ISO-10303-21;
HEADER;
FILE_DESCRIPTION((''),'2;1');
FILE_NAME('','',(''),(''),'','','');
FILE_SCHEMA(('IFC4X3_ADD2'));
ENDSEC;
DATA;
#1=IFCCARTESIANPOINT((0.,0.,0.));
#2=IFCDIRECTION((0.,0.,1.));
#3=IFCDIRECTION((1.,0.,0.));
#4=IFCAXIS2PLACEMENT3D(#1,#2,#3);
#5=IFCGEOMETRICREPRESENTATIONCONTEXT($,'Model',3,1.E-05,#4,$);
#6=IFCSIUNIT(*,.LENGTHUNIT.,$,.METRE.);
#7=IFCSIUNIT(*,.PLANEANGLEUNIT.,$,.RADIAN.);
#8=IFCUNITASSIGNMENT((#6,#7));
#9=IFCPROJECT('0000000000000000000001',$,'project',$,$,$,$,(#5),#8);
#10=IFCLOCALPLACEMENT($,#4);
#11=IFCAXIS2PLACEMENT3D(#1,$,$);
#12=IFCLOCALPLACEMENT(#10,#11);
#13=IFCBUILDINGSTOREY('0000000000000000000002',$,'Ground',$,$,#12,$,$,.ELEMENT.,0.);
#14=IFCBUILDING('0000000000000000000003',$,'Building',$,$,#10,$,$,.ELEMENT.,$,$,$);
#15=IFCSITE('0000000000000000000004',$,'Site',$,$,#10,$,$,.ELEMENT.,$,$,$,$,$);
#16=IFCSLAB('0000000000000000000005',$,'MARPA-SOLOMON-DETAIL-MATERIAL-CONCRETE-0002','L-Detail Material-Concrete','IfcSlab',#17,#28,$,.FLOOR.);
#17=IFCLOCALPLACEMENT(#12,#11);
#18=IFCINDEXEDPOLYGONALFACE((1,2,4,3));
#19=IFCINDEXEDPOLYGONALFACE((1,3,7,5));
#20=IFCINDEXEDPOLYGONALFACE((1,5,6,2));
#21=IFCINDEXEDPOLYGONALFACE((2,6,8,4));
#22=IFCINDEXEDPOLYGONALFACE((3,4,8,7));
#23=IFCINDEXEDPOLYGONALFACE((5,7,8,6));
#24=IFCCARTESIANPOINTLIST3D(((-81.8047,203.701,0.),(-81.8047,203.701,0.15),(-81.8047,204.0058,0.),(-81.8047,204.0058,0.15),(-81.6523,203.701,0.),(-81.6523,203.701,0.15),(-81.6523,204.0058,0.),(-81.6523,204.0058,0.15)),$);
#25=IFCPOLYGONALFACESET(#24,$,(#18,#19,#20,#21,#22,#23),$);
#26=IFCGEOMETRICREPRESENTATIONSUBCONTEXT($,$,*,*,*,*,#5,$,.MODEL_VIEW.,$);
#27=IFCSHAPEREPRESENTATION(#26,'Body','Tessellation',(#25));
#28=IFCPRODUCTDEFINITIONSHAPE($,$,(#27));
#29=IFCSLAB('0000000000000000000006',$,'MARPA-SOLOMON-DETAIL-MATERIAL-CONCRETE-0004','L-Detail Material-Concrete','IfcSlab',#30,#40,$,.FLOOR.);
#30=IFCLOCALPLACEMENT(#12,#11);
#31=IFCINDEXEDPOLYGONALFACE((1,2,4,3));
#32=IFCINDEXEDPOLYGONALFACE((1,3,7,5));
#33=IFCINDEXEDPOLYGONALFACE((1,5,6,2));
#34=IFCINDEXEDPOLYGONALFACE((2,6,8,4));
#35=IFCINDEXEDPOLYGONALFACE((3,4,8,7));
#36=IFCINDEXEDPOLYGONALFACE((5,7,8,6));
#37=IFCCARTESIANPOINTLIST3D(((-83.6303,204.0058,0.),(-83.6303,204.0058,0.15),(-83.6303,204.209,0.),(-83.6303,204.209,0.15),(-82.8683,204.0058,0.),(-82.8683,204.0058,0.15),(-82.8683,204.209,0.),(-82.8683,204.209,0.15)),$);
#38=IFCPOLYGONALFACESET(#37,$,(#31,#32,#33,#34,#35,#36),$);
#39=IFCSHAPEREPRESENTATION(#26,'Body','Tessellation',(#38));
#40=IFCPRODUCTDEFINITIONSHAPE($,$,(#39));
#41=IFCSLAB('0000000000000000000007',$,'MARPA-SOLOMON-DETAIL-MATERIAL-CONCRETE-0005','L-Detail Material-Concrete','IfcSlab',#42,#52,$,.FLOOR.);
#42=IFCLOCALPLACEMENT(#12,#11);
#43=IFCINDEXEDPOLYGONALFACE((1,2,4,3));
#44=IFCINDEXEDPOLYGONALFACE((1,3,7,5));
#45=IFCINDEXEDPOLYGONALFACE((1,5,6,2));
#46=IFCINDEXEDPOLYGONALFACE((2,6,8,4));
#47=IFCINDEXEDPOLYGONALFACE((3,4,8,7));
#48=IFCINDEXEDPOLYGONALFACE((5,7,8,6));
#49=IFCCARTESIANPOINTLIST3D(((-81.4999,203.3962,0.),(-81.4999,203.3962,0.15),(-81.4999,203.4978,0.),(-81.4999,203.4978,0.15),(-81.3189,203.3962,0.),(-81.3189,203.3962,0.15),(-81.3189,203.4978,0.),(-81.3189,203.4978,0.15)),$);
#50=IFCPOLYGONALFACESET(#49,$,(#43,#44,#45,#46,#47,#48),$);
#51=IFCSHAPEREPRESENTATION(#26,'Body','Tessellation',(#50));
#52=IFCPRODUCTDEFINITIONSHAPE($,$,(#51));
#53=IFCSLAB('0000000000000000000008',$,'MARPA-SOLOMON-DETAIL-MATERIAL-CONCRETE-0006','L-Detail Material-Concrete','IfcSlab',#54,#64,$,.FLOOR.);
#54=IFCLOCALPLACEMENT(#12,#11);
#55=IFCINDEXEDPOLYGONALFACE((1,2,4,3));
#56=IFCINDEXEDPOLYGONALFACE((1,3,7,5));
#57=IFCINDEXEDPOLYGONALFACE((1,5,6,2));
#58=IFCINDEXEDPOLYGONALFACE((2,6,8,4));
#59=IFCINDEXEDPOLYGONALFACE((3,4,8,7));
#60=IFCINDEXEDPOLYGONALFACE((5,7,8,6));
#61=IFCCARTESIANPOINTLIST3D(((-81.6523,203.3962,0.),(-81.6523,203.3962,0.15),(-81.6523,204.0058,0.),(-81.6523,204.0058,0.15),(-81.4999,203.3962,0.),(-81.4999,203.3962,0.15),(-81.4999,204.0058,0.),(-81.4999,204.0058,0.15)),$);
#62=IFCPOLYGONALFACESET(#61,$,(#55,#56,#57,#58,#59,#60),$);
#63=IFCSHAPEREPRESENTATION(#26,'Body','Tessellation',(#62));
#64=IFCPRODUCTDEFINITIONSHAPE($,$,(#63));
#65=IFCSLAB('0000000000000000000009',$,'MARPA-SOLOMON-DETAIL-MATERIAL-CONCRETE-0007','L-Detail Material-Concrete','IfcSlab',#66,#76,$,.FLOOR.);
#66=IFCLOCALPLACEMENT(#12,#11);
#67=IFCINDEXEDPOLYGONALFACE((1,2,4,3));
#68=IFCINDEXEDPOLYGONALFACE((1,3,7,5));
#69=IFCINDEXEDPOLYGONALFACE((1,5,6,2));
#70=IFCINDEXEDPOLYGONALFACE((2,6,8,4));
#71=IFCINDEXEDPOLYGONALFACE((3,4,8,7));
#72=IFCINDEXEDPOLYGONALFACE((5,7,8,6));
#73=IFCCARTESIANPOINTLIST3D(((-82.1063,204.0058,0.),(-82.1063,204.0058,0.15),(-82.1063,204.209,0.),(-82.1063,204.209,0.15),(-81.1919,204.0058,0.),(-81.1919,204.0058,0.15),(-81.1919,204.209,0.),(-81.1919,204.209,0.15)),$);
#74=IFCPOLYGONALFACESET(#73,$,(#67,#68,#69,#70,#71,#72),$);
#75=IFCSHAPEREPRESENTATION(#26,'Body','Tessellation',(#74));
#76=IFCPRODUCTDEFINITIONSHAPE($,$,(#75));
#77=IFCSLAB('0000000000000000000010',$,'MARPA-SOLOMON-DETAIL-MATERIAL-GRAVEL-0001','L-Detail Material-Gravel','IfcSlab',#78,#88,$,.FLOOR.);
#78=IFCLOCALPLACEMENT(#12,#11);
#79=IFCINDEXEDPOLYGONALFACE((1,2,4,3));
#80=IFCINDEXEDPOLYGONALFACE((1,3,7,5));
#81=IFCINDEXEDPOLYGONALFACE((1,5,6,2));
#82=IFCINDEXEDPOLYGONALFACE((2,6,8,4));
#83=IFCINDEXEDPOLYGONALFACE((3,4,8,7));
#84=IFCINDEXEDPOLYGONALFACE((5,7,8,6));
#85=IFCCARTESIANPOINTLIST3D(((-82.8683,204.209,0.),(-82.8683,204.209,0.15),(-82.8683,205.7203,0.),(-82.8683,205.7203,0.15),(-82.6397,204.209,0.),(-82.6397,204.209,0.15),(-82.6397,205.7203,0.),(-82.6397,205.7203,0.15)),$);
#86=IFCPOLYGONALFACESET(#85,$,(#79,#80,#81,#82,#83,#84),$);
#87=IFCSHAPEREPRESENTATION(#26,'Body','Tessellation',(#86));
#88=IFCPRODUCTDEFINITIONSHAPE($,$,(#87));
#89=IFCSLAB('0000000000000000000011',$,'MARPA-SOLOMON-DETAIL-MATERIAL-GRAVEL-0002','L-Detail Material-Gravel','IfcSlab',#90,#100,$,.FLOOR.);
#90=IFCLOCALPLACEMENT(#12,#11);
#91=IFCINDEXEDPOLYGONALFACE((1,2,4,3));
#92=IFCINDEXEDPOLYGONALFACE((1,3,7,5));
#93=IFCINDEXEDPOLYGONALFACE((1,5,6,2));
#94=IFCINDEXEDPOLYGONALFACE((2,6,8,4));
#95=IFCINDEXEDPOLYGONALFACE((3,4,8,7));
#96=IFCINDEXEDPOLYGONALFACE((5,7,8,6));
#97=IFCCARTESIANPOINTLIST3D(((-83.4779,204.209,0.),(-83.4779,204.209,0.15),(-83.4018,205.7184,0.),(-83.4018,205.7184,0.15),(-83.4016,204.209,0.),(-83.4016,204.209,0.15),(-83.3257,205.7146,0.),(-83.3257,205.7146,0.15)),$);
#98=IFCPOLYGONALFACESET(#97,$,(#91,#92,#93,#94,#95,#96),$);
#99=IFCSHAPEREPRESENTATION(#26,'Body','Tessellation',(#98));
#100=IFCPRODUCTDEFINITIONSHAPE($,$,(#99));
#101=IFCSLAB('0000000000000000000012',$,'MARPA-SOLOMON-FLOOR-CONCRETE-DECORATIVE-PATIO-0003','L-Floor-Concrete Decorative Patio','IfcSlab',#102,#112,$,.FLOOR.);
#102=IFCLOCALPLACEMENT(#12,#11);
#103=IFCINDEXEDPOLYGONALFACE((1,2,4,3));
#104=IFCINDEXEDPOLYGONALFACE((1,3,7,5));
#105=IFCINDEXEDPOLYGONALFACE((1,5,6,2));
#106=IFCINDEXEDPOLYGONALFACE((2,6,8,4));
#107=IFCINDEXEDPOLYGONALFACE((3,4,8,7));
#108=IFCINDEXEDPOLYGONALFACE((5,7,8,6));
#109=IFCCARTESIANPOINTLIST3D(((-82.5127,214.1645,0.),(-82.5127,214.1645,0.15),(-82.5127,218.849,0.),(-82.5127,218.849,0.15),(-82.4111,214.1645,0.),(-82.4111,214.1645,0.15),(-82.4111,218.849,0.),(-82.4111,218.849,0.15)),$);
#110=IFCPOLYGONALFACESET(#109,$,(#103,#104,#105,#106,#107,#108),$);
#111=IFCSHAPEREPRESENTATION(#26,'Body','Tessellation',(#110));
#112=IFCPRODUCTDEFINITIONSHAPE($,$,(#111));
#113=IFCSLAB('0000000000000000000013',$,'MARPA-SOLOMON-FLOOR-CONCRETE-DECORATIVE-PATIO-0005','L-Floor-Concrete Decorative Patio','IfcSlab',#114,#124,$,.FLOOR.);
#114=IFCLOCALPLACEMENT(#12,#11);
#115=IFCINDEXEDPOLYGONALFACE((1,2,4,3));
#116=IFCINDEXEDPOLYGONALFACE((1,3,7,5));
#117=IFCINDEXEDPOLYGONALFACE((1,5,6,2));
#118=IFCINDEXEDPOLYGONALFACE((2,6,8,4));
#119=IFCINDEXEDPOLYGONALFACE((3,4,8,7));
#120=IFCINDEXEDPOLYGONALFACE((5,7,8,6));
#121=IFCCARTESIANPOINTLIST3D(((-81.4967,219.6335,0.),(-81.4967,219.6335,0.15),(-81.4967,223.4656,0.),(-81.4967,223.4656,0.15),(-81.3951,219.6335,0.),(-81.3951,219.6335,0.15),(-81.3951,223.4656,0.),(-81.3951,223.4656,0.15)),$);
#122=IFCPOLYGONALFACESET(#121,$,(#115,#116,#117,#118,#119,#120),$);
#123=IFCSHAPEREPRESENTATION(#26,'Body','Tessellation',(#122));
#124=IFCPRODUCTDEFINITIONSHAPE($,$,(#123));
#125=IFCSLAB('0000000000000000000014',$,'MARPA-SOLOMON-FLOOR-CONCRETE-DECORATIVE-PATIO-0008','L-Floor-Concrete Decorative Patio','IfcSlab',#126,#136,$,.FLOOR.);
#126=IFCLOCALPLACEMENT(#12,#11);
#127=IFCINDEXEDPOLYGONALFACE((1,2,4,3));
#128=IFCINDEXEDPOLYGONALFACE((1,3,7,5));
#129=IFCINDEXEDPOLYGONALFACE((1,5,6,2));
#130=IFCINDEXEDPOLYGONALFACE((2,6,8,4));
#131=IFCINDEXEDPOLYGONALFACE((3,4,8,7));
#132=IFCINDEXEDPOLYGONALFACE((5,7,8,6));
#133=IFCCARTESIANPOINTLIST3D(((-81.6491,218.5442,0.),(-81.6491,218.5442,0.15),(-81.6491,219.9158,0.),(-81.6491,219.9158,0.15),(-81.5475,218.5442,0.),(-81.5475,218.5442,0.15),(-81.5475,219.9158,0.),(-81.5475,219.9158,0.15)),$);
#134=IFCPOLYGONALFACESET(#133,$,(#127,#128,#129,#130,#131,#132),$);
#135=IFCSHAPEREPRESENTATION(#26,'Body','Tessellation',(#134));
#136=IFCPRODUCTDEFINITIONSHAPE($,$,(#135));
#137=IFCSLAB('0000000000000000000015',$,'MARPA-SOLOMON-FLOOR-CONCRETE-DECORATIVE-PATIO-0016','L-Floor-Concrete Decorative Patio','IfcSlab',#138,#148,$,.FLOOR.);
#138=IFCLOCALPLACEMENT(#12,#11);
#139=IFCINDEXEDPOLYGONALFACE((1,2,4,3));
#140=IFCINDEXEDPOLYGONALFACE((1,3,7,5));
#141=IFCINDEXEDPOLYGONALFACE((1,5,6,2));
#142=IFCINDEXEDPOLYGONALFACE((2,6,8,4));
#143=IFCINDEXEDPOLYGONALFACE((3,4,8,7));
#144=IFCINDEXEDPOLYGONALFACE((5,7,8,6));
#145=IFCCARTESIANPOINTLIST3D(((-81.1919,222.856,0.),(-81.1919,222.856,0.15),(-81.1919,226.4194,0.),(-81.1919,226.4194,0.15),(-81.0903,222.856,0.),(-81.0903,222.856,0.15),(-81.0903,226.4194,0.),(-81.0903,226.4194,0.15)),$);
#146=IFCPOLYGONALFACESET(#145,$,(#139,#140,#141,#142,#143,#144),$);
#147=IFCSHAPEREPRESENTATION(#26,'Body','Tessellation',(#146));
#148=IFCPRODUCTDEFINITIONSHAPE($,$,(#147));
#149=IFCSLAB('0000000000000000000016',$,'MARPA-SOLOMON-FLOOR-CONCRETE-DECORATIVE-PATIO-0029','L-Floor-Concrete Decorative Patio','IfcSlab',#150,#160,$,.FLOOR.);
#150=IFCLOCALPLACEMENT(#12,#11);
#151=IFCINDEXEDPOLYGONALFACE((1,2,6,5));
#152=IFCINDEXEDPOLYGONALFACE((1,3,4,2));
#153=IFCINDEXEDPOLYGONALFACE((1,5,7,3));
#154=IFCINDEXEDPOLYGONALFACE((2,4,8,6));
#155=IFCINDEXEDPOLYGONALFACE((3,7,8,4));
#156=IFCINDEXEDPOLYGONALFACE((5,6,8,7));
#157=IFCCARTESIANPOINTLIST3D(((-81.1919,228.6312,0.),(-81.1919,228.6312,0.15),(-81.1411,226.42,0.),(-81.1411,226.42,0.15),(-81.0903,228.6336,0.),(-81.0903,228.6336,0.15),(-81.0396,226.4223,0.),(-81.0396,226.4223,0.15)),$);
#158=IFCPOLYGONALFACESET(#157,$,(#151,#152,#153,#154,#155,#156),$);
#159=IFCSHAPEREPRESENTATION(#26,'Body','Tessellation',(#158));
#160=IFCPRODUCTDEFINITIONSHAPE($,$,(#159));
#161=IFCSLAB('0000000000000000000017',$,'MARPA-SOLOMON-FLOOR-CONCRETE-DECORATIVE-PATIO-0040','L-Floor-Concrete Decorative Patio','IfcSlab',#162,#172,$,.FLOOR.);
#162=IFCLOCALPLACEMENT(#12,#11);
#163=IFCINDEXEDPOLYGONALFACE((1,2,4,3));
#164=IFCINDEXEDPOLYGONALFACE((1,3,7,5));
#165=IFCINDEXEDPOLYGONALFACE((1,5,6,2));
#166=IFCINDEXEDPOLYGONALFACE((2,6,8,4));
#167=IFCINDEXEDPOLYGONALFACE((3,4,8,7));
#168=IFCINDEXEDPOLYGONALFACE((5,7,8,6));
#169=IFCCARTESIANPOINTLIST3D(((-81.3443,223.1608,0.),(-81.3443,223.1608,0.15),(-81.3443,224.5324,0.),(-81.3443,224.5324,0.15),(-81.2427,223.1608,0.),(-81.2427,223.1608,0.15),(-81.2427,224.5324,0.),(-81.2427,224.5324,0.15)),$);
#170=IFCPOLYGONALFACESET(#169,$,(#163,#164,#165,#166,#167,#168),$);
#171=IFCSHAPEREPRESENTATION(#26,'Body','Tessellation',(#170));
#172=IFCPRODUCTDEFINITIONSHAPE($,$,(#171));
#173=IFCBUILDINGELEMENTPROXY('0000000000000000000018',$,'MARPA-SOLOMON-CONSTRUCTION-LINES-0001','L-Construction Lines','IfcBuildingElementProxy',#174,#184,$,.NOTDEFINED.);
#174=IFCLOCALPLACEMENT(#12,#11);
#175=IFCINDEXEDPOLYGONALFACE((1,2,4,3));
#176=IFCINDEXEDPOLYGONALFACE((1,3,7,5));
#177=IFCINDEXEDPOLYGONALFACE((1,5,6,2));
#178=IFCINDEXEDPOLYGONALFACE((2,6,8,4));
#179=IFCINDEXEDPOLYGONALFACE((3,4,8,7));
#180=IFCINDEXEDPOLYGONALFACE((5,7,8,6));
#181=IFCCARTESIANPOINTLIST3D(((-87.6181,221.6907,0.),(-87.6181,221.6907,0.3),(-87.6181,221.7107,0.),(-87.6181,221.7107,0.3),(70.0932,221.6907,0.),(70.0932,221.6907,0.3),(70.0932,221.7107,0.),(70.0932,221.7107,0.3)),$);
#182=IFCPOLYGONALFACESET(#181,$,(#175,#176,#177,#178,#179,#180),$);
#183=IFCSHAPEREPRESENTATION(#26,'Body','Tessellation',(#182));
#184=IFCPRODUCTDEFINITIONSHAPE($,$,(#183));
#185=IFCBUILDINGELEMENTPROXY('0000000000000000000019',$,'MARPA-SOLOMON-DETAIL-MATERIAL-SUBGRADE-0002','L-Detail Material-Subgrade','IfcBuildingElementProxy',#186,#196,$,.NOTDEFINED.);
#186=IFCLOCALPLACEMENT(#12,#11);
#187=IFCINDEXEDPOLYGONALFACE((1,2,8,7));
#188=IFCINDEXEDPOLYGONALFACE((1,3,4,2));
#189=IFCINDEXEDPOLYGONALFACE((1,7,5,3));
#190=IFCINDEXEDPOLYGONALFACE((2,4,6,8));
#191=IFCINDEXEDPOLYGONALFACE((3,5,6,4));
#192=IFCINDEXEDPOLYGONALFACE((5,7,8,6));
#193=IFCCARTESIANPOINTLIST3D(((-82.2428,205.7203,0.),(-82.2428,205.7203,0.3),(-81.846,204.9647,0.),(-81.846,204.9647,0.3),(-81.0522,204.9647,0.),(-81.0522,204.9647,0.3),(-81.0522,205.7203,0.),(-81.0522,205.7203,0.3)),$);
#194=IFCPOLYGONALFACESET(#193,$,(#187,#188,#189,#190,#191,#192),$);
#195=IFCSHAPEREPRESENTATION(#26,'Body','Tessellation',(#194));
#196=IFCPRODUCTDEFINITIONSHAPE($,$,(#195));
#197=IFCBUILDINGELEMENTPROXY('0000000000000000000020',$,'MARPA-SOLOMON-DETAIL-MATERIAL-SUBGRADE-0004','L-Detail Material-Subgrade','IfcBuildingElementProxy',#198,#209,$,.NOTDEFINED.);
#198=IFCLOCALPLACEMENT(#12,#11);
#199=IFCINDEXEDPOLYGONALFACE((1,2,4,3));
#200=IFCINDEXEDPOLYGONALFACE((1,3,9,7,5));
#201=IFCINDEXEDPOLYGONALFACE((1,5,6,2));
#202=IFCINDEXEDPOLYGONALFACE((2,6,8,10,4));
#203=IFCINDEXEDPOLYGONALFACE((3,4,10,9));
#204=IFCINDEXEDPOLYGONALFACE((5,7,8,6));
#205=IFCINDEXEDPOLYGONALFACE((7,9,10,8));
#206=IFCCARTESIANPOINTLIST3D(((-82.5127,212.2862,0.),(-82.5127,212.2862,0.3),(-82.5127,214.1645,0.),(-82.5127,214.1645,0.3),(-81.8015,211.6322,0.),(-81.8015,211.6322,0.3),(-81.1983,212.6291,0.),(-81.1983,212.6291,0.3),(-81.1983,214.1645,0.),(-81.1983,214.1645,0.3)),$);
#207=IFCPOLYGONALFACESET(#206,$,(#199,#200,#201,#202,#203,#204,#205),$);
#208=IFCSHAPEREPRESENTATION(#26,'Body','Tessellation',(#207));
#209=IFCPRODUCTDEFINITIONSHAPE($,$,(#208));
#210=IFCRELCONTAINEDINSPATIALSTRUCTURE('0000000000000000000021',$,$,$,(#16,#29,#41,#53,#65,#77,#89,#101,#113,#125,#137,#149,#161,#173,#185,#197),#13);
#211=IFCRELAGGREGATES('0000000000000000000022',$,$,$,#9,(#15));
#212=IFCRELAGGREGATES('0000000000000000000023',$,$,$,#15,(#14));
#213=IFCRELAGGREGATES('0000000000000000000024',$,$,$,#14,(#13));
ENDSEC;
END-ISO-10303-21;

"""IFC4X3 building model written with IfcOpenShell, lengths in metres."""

from ifc_helpers import new_model, si_unit, frame, frame_2d, origin, origin_with_axes, place, context, subcontext, project, spatial, polyline, rectangle, outline, extrude, element, save


model = new_model("IFC4X3")

# Units and contexts
model_context = context("Model", 3, precision=1e-05, world=origin_with_axes())
sub_context = subcontext(model_context, None, None, "MODEL_VIEW")
ifc_project = project(units=[si_unit("LENGTHUNIT", "METRE"), si_unit("PLANEANGLEUNIT", "RADIAN")], contexts=[model_context])

# Site, building, storey
placement = place(None, origin_with_axes())
site = spatial("IfcSite", under=ifc_project, at=placement, Name="Site", CompositionType="ELEMENT")
building = spatial("IfcBuilding", under=site, at=placement, Name="Building", CompositionType="ELEMENT")
storey_placement = place(placement, origin())
storey = spatial("IfcBuildingStorey", under=building, at=storey_placement, Name="Ground", CompositionType="ELEMENT", Elevation=0.0)

# Slabs
slab_1_placement = place(storey_placement, frame((-81.8047, 203.701, 0.0)))
element("IfcSlab", 1, at=slab_1_placement, inside=storey, Name="MARPA-SOLOMON-DETAIL-MATERIAL-CONCRETE-0002", Description="L-Detail Material-Concrete", ObjectType="IfcSlab", PredefinedType="FLOOR", context=sub_context, shape_type="SweptSolid", body=[
    extrude(outline(polyline([(0.0, 0.0), (0.0, 0.3048), (0.1524, 0.3048), (0.1524, 0.0), (0.0, 0.0)])), origin(), (0.0, 0.0, 1.0), 0.15),
])
slab_2_placement = place(storey_placement, frame((-83.6303, 204.0058, 0.0)))
element("IfcSlab", 2, at=slab_2_placement, inside=storey, Name="MARPA-SOLOMON-DETAIL-MATERIAL-CONCRETE-0004", Description="L-Detail Material-Concrete", ObjectType="IfcSlab", PredefinedType="FLOOR", context=sub_context, shape_type="SweptSolid", body=[
    extrude(outline(polyline([(0.0, 0.0), (0.0, 0.2032), (0.762, 0.2032), (0.762, 0.0), (0.0, 0.0)])), origin(), (0.0, 0.0, 1.0), 0.15),
])
slab_3_placement = place(storey_placement, frame((-81.4999, 203.3962, 0.0)))
element("IfcSlab", 3, at=slab_3_placement, inside=storey, Name="MARPA-SOLOMON-DETAIL-MATERIAL-CONCRETE-0005", Description="L-Detail Material-Concrete", ObjectType="IfcSlab", PredefinedType="FLOOR", context=sub_context, shape_type="SweptSolid", body=[
    extrude(outline(polyline([(0.0, 0.0), (0.0, 0.1016), (0.181, 0.1016), (0.181, 0.0), (0.0, 0.0)])), origin(), (0.0, 0.0, 1.0), 0.15),
])
slab_4_placement = place(storey_placement, frame((-81.6523, 203.3962, 0.0)))
element("IfcSlab", 4, at=slab_4_placement, inside=storey, Name="MARPA-SOLOMON-DETAIL-MATERIAL-CONCRETE-0006", Description="L-Detail Material-Concrete", ObjectType="IfcSlab", PredefinedType="FLOOR", context=sub_context, shape_type="SweptSolid", body=[
    extrude(outline(polyline([(0.0, 0.0), (0.0, 0.6096), (0.1524, 0.6096), (0.1524, 0.0), (0.0, 0.0)])), origin(), (0.0, 0.0, 1.0), 0.15),
])
slab_5_placement = place(storey_placement, frame((-82.1063, 204.0058, 0.0)))
element("IfcSlab", 5, at=slab_5_placement, inside=storey, Name="MARPA-SOLOMON-DETAIL-MATERIAL-CONCRETE-0007", Description="L-Detail Material-Concrete", ObjectType="IfcSlab", PredefinedType="FLOOR", context=sub_context, shape_type="SweptSolid", body=[
    extrude(outline(polyline([(0.9144, 0.0), (0.0, 0.0), (0.0, 0.2032), (0.9144, 0.2032), (0.9144, 0.0)])), origin(), (0.0, 0.0, 1.0), 0.15),
])
slab_6_placement = place(storey_placement, frame((-82.8683, 204.209, 0.0)))
element("IfcSlab", 6, at=slab_6_placement, inside=storey, Name="MARPA-SOLOMON-DETAIL-MATERIAL-GRAVEL-0001", Description="L-Detail Material-Gravel", ObjectType="IfcSlab", PredefinedType="FLOOR", context=sub_context, shape_type="SweptSolid", body=[
    extrude(outline(polyline([(0.0, 0.0), (0.0, 1.5113), (0.2286, 1.5113), (0.2286, 0.0), (0.0, 0.0)])), origin(), (0.0, 0.0, 1.0), 0.15),
])
slab_7_placement = place(storey_placement, frame((-83.4779, 204.209, 0.0)))
element("IfcSlab", 7, at=slab_7_placement, inside=storey, Name="MARPA-SOLOMON-DETAIL-MATERIAL-GRAVEL-0002", Description="L-Detail Material-Gravel", ObjectType="IfcSlab", PredefinedType="FLOOR", context=sub_context, shape_type="SweptSolid", body=[
    extrude(outline(polyline([(0.0, 0.0), (0.0761, 1.5094), (0.1522, 1.5055), (0.0763, 0.0), (0.0, 0.0)])), origin(), (0.0, 0.0, 1.0), 0.15),
])
slab_8_placement = place(storey_placement, frame((-82.5127, 214.1645, 0.0)))
element("IfcSlab", 8, at=slab_8_placement, inside=storey, Name="MARPA-SOLOMON-FLOOR-CONCRETE-DECORATIVE-PATIO-0003", Description="L-Floor-Concrete Decorative Patio", ObjectType="IfcSlab", PredefinedType="FLOOR", context=sub_context, shape_type="SweptSolid", body=[
    extrude(outline(polyline([(0.0, 0.0), (0.0, 4.6845), (0.1016, 4.6845), (0.1016, 0.0), (0.0, 0.0)])), origin(), (0.0, 0.0, 1.0), 0.15),
])
slab_9_placement = place(storey_placement, frame((-81.4967, 219.6335, 0.0)))
element("IfcSlab", 9, at=slab_9_placement, inside=storey, Name="MARPA-SOLOMON-FLOOR-CONCRETE-DECORATIVE-PATIO-0005", Description="L-Floor-Concrete Decorative Patio", ObjectType="IfcSlab", PredefinedType="FLOOR", context=sub_context, shape_type="SweptSolid", body=[
    extrude(outline(polyline([(0.0, 0.0), (0.0, 3.8321), (0.1016, 3.8321), (0.1016, 0.0), (0.0, 0.0)])), origin(), (0.0, 0.0, 1.0), 0.15),
])
slab_10_placement = place(storey_placement, frame((-81.6491, 218.5442, 0.0)))
element("IfcSlab", 10, at=slab_10_placement, inside=storey, Name="MARPA-SOLOMON-FLOOR-CONCRETE-DECORATIVE-PATIO-0008", Description="L-Floor-Concrete Decorative Patio", ObjectType="IfcSlab", PredefinedType="FLOOR", context=sub_context, shape_type="SweptSolid", body=[
    extrude(outline(polyline([(0.0, 0.0), (0.0, 1.3716), (0.1016, 1.3716), (0.1016, 0.0), (0.0, 0.0)])), origin(), (0.0, 0.0, 1.0), 0.15),
])
slab_11_placement = place(storey_placement, frame((-81.1919, 222.856, 0.0)))
element("IfcSlab", 11, at=slab_11_placement, inside=storey, Name="MARPA-SOLOMON-FLOOR-CONCRETE-DECORATIVE-PATIO-0016", Description="L-Floor-Concrete Decorative Patio", ObjectType="IfcSlab", PredefinedType="FLOOR", context=sub_context, shape_type="SweptSolid", body=[
    extrude(outline(polyline([(0.0, 0.0), (0.0, 3.5633), (0.1016, 3.5633), (0.1016, 0.0), (0.0, 0.0)])), origin(), (0.0, 0.0, 1.0), 0.15),
])
slab_12_placement = place(storey_placement, frame((-81.1919, 226.42, 0.0)))
element("IfcSlab", 12, at=slab_12_placement, inside=storey, Name="MARPA-SOLOMON-FLOOR-CONCRETE-DECORATIVE-PATIO-0029", Description="L-Floor-Concrete Decorative Patio", ObjectType="IfcSlab", PredefinedType="FLOOR", context=sub_context, shape_type="SweptSolid", body=[
    extrude(outline(polyline([(0.0508, 0.0), (0.0, 2.2113), (0.1016, 2.2136), (0.1524, 0.0023), (0.0508, 0.0)])), origin(), (0.0, 0.0, 1.0), 0.15),
])
slab_13_placement = place(storey_placement, frame((-81.3443, 223.1608, 0.0)))
element("IfcSlab", 13, at=slab_13_placement, inside=storey, Name="MARPA-SOLOMON-FLOOR-CONCRETE-DECORATIVE-PATIO-0040", Description="L-Floor-Concrete Decorative Patio", ObjectType="IfcSlab", PredefinedType="FLOOR", context=sub_context, shape_type="SweptSolid", body=[
    extrude(outline(polyline([(0.0, 0.0), (0.0, 1.3716), (0.1016, 1.3716), (0.1016, 0.0), (0.0, 0.0)])), origin(), (0.0, 0.0, 1.0), 0.15),
])

# Building element proxies
proxy_1_placement = place(placement, frame((-87.6181, 221.6907, 0.0)))
element("IfcBuildingElementProxy", 14, at=proxy_1_placement, inside=storey, Name="MARPA-SOLOMON-CONSTRUCTION-LINES-0001", Description="L-Construction Lines", ObjectType="IfcBuildingElementProxy", PredefinedType="NOTDEFINED", context=sub_context, shape_type="SweptSolid", body=[
    extrude(rectangle(XDim=157.7113, YDim=0.02, at=frame_2d((78.8557, 0.01))), origin(), (0.0, 0.0, 1.0), 0.3),
])
proxy_2_placement = place(placement, frame((-82.2428, 204.9647, 0.0)))
element("IfcBuildingElementProxy", 15, at=proxy_2_placement, inside=storey, Name="MARPA-SOLOMON-DETAIL-MATERIAL-SUBGRADE-0002", Description="L-Detail Material-Subgrade", ObjectType="IfcBuildingElementProxy", PredefinedType="NOTDEFINED", context=sub_context, shape_type="SweptSolid", body=[
    extrude(outline(polyline([(0.0, 0.7556), (0.3969, 0.0), (1.1906, 0.0), (1.1906, 0.7556), (0.0, 0.7556)])), origin(), (0.0, 0.0, 1.0), 0.3),
])
proxy_3_placement = place(placement, frame((-82.5127, 211.6322, 0.0)))
element("IfcBuildingElementProxy", 16, at=proxy_3_placement, inside=storey, Name="MARPA-SOLOMON-DETAIL-MATERIAL-SUBGRADE-0004", Description="L-Detail Material-Subgrade", ObjectType="IfcBuildingElementProxy", PredefinedType="NOTDEFINED", context=sub_context, shape_type="SweptSolid", body=[
    extrude(outline(polyline([(0.0, 2.5323), (0.0, 0.6541), (0.7112, 0.0), (1.3144, 0.9969), (1.3144, 2.5323), (0.0, 2.5323)])), origin(), (0.0, 0.0, 1.0), 0.3),
])

save(model, "model.ifc")
